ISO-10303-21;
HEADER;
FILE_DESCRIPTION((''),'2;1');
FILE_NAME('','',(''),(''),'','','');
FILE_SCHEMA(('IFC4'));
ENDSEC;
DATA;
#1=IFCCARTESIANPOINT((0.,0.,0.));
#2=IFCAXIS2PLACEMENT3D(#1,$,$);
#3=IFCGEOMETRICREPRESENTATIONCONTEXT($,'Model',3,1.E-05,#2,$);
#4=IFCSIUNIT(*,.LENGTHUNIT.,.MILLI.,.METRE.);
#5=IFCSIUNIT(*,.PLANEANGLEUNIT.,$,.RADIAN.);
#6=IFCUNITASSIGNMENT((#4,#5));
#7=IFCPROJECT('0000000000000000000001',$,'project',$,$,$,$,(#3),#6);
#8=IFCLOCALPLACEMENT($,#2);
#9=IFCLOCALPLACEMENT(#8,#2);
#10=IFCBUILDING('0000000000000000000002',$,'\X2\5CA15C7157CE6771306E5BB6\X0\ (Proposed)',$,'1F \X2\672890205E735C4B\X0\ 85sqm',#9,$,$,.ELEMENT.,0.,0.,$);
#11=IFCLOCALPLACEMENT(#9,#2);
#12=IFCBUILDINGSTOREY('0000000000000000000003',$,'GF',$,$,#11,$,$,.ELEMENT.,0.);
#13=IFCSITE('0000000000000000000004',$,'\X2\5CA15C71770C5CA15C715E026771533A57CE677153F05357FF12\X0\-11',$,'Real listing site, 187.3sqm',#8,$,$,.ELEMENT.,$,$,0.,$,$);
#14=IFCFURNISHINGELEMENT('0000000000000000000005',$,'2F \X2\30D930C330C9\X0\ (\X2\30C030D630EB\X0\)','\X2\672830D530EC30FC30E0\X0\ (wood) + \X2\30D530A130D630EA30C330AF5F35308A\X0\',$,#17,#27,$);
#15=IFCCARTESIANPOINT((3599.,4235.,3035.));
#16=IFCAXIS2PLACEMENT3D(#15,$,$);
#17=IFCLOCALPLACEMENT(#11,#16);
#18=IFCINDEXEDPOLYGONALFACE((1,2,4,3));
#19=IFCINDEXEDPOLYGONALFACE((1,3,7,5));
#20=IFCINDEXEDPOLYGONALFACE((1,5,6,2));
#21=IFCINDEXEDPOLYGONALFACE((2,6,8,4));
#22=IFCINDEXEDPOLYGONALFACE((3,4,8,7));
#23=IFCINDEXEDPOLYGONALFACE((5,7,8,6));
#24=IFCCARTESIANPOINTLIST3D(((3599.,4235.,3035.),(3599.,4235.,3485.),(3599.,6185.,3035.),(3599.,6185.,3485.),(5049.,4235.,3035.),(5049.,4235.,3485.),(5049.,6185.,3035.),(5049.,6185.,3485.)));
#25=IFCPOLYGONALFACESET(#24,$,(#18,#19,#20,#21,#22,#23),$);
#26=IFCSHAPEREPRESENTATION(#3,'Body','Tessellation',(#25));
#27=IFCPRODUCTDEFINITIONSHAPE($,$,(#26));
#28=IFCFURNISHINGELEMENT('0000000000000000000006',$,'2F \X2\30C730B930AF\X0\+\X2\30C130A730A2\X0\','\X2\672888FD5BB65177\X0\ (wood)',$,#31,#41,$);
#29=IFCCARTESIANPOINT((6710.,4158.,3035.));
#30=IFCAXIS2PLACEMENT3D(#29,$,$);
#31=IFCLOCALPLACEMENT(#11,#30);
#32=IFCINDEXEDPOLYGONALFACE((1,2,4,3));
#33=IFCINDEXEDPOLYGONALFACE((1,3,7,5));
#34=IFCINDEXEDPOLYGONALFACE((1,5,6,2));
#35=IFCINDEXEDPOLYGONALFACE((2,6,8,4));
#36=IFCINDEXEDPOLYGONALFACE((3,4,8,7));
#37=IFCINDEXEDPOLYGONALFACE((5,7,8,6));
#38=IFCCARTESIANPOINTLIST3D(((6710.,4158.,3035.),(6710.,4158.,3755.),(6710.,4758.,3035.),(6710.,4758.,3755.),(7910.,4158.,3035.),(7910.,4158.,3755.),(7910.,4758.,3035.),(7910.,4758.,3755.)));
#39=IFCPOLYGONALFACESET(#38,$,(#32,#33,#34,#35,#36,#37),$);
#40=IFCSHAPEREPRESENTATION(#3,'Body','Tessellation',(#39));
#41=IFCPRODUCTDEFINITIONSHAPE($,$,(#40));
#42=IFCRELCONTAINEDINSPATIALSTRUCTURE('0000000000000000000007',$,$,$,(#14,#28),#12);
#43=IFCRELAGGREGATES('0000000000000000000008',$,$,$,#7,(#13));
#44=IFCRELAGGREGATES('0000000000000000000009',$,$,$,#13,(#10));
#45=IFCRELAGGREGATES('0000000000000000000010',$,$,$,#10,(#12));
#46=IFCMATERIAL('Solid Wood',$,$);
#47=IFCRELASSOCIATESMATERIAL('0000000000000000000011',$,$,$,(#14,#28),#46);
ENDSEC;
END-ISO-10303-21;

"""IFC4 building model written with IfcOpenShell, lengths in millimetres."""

from ifc_helpers import new_model, si_unit, frame, frame_2d, origin, place, context, project, spatial, rectangle, extrude, material, element, save


model = new_model("IFC4")

# Units and contexts
model_context = context("Model", 3, precision=1e-05, world=origin())
ifc_project = project(units=[si_unit("LENGTHUNIT", "METRE", prefix="MILLI"), si_unit("PLANEANGLEUNIT", "RADIAN")], contexts=[model_context])

# Site, building, storey
site_placement = place(None, origin())
site = spatial("IfcSite", under=ifc_project, at=site_placement, Name="岡山県岡山市東区城東台南２-11", ObjectType="Real listing site, 187.3sqm", CompositionType="ELEMENT", RefElevation=0.0)
building_placement = place(site_placement, origin())
building = spatial("IfcBuilding", under=site, at=building_placement, Name="岡山城東の家 (Proposed)", ObjectType="1F 木造平屋 85sqm", CompositionType="ELEMENT", ElevationOfRefHeight=0.0, ElevationOfTerrain=0.0)
storey_placement = place(building_placement, origin())
storey = spatial("IfcBuildingStorey", under=building, at=storey_placement, Name="GF", CompositionType="ELEMENT", Elevation=0.0)

# Shared definitions
ifc_material_1 = material(Name="Solid Wood")

# Furnishing elements
furnishing_1_placement = place(storey_placement, frame((3599.0, 4235.0, 3035.0)))
element("IfcFurnishingElement", 1, at=furnishing_1_placement, inside=storey, material=ifc_material_1, Name="2F ベッド (ダブル)", Description="木フレーム (wood) + ファブリック張り", context=model_context, shape_type="SweptSolid", body=[
    extrude(rectangle(XDim=1450.0, YDim=1950.0, at=frame_2d((725.0, 975.0))), frame((3599.0, 4235.0, 3035.0)), (0.0, 0.0, 1.0), 450.0),
])
furnishing_2_placement = place(storey_placement, frame((6710.0, 4158.0, 3035.0)))
element("IfcFurnishingElement", 2, at=furnishing_2_placement, inside=storey, material=ifc_material_1, Name="2F デスク+チェア", Description="木製家具 (wood)", context=model_context, shape_type="SweptSolid", body=[
    extrude(rectangle(XDim=1200.0, YDim=600.0, at=frame_2d((600.0, 300.0))), frame((6710.0, 4158.0, 3035.0)), (0.0, 0.0, 1.0), 720.0),
])

save(model, "model.ifc")
